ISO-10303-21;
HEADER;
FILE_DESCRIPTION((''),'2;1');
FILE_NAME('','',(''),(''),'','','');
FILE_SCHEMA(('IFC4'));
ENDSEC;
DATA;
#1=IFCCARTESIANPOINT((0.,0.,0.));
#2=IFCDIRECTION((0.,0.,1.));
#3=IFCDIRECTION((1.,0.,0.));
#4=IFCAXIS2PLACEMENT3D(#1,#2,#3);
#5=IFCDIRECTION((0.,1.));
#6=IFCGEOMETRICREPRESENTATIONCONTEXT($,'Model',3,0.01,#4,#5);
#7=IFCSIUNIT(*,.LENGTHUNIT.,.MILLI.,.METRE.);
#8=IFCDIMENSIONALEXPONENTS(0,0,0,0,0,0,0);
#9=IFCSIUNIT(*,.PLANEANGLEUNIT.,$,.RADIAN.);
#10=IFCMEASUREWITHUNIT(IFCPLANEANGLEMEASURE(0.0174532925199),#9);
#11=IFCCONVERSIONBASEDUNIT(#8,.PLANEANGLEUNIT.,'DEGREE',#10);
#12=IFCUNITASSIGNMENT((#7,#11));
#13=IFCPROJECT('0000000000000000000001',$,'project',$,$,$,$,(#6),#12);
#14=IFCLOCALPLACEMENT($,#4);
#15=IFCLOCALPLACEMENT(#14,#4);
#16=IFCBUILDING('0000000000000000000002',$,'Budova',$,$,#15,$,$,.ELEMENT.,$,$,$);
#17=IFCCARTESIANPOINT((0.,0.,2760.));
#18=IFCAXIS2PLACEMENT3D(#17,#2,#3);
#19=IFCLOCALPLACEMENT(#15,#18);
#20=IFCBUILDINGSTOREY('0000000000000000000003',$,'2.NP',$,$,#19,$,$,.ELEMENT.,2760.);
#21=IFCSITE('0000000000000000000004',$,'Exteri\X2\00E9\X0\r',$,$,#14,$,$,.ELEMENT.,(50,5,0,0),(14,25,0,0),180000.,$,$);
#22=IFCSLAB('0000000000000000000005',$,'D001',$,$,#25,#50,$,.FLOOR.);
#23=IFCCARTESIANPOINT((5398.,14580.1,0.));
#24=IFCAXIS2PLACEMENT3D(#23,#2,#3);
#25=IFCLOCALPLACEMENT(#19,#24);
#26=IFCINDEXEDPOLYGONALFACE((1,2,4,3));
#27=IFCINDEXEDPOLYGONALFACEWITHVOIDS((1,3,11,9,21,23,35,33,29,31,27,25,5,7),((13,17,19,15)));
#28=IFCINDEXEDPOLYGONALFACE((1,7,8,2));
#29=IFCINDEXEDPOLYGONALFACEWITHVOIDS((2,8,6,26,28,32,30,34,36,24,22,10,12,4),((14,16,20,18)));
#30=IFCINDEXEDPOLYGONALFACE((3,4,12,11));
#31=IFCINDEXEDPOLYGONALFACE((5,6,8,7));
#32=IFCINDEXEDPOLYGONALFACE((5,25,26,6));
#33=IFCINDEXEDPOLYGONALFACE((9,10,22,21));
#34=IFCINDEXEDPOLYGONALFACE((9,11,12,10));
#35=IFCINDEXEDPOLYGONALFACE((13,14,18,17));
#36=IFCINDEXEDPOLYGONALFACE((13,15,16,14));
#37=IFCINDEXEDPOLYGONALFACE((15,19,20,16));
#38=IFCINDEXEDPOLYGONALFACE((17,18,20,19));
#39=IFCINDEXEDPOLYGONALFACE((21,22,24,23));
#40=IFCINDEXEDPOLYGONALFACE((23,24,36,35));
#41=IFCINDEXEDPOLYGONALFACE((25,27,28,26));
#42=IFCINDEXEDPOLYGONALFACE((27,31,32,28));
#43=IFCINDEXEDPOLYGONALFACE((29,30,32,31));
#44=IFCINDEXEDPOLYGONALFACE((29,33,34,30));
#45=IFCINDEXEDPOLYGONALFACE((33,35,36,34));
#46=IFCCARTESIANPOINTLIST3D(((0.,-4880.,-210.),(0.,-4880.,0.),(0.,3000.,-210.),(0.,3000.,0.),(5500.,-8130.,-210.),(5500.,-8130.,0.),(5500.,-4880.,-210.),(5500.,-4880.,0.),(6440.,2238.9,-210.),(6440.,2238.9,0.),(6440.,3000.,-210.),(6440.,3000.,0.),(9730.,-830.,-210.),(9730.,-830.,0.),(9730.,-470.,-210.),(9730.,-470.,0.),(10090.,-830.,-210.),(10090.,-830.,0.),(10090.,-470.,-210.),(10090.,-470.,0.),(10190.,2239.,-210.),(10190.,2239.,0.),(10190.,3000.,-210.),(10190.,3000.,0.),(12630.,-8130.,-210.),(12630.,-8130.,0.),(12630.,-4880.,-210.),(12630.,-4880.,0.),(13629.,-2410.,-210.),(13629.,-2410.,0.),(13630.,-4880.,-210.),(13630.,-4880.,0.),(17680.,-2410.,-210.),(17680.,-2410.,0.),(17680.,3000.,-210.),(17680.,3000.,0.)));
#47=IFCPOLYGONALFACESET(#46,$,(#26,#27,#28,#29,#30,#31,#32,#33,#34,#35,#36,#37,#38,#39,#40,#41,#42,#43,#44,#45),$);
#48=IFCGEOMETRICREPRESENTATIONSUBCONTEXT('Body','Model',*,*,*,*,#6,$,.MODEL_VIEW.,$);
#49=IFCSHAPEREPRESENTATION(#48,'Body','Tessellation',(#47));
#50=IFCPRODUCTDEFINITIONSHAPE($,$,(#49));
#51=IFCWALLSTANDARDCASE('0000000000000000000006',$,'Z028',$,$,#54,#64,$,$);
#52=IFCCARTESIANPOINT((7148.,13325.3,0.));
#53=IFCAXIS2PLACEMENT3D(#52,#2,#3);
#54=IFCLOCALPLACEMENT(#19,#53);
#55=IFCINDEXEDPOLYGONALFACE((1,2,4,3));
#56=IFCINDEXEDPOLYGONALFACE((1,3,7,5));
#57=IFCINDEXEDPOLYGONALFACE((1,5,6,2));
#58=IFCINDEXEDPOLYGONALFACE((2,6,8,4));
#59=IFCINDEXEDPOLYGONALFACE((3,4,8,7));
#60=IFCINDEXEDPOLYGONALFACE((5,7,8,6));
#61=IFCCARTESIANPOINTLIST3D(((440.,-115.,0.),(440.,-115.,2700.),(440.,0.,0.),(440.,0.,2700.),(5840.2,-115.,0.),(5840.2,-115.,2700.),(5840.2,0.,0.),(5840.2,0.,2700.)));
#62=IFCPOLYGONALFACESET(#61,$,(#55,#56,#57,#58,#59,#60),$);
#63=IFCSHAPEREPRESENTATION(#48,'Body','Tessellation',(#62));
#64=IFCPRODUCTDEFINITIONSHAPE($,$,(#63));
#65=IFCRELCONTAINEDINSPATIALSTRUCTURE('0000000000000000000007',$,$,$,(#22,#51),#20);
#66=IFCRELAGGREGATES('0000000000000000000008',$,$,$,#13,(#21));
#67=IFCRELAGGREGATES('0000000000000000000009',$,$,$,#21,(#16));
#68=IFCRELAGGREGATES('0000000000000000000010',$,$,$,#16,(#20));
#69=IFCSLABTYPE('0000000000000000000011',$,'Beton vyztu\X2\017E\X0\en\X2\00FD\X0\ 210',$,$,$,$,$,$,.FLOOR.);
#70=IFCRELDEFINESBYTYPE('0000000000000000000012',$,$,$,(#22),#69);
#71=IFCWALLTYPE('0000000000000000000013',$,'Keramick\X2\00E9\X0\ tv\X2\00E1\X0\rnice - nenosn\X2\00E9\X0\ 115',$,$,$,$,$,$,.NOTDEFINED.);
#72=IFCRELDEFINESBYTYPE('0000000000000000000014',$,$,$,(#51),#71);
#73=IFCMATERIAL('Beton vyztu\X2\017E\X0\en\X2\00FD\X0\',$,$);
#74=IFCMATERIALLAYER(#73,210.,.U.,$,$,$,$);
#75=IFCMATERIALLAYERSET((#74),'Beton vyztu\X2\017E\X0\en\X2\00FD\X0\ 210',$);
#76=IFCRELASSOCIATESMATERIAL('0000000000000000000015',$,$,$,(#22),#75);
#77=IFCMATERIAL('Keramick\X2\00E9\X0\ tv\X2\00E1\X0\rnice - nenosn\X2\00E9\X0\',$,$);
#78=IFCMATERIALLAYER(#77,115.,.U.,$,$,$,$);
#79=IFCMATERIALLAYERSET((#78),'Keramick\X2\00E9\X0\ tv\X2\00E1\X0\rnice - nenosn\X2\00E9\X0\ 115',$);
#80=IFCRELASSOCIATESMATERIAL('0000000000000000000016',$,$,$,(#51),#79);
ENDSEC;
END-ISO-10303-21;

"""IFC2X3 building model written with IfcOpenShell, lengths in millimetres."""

from ifc_helpers import new_model, entity, si_unit, converted_unit, direction, frame, origin_with_axes, place, context, subcontext, project, spatial, polyline, outline, extrude, material, layer, layer_set, layer_usage, type_object, element, save


model = new_model("IFC2X3")

# Units and contexts
model_context = context("Model", 3, precision=0.01, world=origin_with_axes(), true_north=direction((0.0, 1.0)))
body_context = subcontext(model_context, "Body", "Model", "MODEL_VIEW")
ifc_project = project(units=[si_unit("LENGTHUNIT", "METRE", prefix="MILLI"), converted_unit("PLANEANGLEUNIT", "DEGREE", entity("IfcPlaneAngleMeasure", 0.0174532925199), si_unit("PLANEANGLEUNIT", "RADIAN"), dimensions=[0, 0, 0, 0, 0, 0, 0])], contexts=[model_context])

# Site, building, storey
site_placement = place(None, origin_with_axes())
site = spatial("IfcSite", under=ifc_project, at=site_placement, Name="Exteriér", CompositionType="ELEMENT", RefLatitude=(50, 5, 0, 0), RefLongitude=(14, 25, 0, 0), RefElevation=180000.0)
building_placement = place(site_placement, origin_with_axes())
building = spatial("IfcBuilding", under=site, at=building_placement, Name="Budova", CompositionType="ELEMENT")
storey_placement = place(building_placement, frame((0.0, 0.0, 2760.0), z_axis=(0.0, 0.0, 1.0), x_axis=(1.0, 0.0, 0.0)))
storey = spatial("IfcBuildingStorey", under=building, at=storey_placement, Name="2.NP", CompositionType="ELEMENT", Elevation=2760.0)

# Slab
ifc_material_1 = material(Name="Beton vyztužený")
ifc_layer_1 = layer(ifc_material_1, 210.0, ventilated="UNKNOWN")
ifc_layer_set_1 = layer_set([ifc_layer_1], Name="Beton vyztužený 210")
ifc_layer_usage_1 = layer_usage(ifc_layer_set_1, "AXIS3", "NEGATIVE", 210.0)
slab_type_1 = type_object("IfcSlabType", Name="Beton vyztužený 210", PredefinedType="FLOOR")
slab_1_placement = place(storey_placement, frame((5398.0, 14580.1, 0.0), z_axis=(0.0, 0.0, 1.0), x_axis=(1.0, 0.0, 0.0)))
element("IfcSlab", 1, at=slab_1_placement, inside=storey, type_object=slab_type_1, material=ifc_layer_usage_1, Name="D001", PredefinedType="FLOOR", context=body_context, shape_type="SweptSolid", body=[
    extrude(outline(polyline([(0.0, -4880.0), (5500.0, -4880.0), (5500.0, -8130.0), (12630.0, -8130.0), (12630.0, -4880.0), (13630.0, -4880.0), (13629.0, -2410.0), (17680.0, -2410.0), (17680.0, 3000.0), (10190.0, 3000.0), (10190.0, 2239.0), (6440.0, 2238.9), (6440.0, 3000.0), (0.0, 3000.0), (0.0, -4880.0)]), holes=[polyline([(9730.0, -470.0), (10090.0, -470.0), (10090.0, -830.0), (9730.0, -830.0), (9730.0, -470.0)])]), frame((0.0, 0.0, -210.0), z_axis=(0.0, 0.0, 1.0), x_axis=(1.0, 0.0, 0.0)), (0.0, 0.0, 1.0), 210.0),
])

# Shared definitions
ifc_material_2 = material(Name="Keramické tvárnice - nenosné")
ifc_layer_2 = layer(ifc_material_2, 115.0, ventilated="UNKNOWN")
ifc_layer_set_2 = layer_set([ifc_layer_2], Name="Keramické tvárnice - nenosné 115")
wall_type_1 = type_object("IfcWallType", Name="Keramické tvárnice - nenosné 115", PredefinedType="NOTDEFINED")

# Wall
ifc_layer_usage_2 = layer_usage(ifc_layer_set_2, "AXIS2", "POSITIVE", -115.0)
wall_1_placement = place(storey_placement, frame((7148.0, 13325.3, 0.0), z_axis=(0.0, 0.0, 1.0), x_axis=(1.0, 0.0, 0.0)))
element("IfcWallStandardCase", 2, at=wall_1_placement, inside=storey, type_object=wall_type_1, material=ifc_layer_usage_2, Name="Z028", context=body_context, shape_type="SweptSolid", body=[
    extrude(outline(polyline([(440.0, -115.0), (5840.2, -115.0), (5840.2, 0.0), (440.0, 0.0), (440.0, -115.0)])), origin_with_axes(), (0.0, 0.0, 1.0), 2700.0),
])

save(model, "model.ifc")
